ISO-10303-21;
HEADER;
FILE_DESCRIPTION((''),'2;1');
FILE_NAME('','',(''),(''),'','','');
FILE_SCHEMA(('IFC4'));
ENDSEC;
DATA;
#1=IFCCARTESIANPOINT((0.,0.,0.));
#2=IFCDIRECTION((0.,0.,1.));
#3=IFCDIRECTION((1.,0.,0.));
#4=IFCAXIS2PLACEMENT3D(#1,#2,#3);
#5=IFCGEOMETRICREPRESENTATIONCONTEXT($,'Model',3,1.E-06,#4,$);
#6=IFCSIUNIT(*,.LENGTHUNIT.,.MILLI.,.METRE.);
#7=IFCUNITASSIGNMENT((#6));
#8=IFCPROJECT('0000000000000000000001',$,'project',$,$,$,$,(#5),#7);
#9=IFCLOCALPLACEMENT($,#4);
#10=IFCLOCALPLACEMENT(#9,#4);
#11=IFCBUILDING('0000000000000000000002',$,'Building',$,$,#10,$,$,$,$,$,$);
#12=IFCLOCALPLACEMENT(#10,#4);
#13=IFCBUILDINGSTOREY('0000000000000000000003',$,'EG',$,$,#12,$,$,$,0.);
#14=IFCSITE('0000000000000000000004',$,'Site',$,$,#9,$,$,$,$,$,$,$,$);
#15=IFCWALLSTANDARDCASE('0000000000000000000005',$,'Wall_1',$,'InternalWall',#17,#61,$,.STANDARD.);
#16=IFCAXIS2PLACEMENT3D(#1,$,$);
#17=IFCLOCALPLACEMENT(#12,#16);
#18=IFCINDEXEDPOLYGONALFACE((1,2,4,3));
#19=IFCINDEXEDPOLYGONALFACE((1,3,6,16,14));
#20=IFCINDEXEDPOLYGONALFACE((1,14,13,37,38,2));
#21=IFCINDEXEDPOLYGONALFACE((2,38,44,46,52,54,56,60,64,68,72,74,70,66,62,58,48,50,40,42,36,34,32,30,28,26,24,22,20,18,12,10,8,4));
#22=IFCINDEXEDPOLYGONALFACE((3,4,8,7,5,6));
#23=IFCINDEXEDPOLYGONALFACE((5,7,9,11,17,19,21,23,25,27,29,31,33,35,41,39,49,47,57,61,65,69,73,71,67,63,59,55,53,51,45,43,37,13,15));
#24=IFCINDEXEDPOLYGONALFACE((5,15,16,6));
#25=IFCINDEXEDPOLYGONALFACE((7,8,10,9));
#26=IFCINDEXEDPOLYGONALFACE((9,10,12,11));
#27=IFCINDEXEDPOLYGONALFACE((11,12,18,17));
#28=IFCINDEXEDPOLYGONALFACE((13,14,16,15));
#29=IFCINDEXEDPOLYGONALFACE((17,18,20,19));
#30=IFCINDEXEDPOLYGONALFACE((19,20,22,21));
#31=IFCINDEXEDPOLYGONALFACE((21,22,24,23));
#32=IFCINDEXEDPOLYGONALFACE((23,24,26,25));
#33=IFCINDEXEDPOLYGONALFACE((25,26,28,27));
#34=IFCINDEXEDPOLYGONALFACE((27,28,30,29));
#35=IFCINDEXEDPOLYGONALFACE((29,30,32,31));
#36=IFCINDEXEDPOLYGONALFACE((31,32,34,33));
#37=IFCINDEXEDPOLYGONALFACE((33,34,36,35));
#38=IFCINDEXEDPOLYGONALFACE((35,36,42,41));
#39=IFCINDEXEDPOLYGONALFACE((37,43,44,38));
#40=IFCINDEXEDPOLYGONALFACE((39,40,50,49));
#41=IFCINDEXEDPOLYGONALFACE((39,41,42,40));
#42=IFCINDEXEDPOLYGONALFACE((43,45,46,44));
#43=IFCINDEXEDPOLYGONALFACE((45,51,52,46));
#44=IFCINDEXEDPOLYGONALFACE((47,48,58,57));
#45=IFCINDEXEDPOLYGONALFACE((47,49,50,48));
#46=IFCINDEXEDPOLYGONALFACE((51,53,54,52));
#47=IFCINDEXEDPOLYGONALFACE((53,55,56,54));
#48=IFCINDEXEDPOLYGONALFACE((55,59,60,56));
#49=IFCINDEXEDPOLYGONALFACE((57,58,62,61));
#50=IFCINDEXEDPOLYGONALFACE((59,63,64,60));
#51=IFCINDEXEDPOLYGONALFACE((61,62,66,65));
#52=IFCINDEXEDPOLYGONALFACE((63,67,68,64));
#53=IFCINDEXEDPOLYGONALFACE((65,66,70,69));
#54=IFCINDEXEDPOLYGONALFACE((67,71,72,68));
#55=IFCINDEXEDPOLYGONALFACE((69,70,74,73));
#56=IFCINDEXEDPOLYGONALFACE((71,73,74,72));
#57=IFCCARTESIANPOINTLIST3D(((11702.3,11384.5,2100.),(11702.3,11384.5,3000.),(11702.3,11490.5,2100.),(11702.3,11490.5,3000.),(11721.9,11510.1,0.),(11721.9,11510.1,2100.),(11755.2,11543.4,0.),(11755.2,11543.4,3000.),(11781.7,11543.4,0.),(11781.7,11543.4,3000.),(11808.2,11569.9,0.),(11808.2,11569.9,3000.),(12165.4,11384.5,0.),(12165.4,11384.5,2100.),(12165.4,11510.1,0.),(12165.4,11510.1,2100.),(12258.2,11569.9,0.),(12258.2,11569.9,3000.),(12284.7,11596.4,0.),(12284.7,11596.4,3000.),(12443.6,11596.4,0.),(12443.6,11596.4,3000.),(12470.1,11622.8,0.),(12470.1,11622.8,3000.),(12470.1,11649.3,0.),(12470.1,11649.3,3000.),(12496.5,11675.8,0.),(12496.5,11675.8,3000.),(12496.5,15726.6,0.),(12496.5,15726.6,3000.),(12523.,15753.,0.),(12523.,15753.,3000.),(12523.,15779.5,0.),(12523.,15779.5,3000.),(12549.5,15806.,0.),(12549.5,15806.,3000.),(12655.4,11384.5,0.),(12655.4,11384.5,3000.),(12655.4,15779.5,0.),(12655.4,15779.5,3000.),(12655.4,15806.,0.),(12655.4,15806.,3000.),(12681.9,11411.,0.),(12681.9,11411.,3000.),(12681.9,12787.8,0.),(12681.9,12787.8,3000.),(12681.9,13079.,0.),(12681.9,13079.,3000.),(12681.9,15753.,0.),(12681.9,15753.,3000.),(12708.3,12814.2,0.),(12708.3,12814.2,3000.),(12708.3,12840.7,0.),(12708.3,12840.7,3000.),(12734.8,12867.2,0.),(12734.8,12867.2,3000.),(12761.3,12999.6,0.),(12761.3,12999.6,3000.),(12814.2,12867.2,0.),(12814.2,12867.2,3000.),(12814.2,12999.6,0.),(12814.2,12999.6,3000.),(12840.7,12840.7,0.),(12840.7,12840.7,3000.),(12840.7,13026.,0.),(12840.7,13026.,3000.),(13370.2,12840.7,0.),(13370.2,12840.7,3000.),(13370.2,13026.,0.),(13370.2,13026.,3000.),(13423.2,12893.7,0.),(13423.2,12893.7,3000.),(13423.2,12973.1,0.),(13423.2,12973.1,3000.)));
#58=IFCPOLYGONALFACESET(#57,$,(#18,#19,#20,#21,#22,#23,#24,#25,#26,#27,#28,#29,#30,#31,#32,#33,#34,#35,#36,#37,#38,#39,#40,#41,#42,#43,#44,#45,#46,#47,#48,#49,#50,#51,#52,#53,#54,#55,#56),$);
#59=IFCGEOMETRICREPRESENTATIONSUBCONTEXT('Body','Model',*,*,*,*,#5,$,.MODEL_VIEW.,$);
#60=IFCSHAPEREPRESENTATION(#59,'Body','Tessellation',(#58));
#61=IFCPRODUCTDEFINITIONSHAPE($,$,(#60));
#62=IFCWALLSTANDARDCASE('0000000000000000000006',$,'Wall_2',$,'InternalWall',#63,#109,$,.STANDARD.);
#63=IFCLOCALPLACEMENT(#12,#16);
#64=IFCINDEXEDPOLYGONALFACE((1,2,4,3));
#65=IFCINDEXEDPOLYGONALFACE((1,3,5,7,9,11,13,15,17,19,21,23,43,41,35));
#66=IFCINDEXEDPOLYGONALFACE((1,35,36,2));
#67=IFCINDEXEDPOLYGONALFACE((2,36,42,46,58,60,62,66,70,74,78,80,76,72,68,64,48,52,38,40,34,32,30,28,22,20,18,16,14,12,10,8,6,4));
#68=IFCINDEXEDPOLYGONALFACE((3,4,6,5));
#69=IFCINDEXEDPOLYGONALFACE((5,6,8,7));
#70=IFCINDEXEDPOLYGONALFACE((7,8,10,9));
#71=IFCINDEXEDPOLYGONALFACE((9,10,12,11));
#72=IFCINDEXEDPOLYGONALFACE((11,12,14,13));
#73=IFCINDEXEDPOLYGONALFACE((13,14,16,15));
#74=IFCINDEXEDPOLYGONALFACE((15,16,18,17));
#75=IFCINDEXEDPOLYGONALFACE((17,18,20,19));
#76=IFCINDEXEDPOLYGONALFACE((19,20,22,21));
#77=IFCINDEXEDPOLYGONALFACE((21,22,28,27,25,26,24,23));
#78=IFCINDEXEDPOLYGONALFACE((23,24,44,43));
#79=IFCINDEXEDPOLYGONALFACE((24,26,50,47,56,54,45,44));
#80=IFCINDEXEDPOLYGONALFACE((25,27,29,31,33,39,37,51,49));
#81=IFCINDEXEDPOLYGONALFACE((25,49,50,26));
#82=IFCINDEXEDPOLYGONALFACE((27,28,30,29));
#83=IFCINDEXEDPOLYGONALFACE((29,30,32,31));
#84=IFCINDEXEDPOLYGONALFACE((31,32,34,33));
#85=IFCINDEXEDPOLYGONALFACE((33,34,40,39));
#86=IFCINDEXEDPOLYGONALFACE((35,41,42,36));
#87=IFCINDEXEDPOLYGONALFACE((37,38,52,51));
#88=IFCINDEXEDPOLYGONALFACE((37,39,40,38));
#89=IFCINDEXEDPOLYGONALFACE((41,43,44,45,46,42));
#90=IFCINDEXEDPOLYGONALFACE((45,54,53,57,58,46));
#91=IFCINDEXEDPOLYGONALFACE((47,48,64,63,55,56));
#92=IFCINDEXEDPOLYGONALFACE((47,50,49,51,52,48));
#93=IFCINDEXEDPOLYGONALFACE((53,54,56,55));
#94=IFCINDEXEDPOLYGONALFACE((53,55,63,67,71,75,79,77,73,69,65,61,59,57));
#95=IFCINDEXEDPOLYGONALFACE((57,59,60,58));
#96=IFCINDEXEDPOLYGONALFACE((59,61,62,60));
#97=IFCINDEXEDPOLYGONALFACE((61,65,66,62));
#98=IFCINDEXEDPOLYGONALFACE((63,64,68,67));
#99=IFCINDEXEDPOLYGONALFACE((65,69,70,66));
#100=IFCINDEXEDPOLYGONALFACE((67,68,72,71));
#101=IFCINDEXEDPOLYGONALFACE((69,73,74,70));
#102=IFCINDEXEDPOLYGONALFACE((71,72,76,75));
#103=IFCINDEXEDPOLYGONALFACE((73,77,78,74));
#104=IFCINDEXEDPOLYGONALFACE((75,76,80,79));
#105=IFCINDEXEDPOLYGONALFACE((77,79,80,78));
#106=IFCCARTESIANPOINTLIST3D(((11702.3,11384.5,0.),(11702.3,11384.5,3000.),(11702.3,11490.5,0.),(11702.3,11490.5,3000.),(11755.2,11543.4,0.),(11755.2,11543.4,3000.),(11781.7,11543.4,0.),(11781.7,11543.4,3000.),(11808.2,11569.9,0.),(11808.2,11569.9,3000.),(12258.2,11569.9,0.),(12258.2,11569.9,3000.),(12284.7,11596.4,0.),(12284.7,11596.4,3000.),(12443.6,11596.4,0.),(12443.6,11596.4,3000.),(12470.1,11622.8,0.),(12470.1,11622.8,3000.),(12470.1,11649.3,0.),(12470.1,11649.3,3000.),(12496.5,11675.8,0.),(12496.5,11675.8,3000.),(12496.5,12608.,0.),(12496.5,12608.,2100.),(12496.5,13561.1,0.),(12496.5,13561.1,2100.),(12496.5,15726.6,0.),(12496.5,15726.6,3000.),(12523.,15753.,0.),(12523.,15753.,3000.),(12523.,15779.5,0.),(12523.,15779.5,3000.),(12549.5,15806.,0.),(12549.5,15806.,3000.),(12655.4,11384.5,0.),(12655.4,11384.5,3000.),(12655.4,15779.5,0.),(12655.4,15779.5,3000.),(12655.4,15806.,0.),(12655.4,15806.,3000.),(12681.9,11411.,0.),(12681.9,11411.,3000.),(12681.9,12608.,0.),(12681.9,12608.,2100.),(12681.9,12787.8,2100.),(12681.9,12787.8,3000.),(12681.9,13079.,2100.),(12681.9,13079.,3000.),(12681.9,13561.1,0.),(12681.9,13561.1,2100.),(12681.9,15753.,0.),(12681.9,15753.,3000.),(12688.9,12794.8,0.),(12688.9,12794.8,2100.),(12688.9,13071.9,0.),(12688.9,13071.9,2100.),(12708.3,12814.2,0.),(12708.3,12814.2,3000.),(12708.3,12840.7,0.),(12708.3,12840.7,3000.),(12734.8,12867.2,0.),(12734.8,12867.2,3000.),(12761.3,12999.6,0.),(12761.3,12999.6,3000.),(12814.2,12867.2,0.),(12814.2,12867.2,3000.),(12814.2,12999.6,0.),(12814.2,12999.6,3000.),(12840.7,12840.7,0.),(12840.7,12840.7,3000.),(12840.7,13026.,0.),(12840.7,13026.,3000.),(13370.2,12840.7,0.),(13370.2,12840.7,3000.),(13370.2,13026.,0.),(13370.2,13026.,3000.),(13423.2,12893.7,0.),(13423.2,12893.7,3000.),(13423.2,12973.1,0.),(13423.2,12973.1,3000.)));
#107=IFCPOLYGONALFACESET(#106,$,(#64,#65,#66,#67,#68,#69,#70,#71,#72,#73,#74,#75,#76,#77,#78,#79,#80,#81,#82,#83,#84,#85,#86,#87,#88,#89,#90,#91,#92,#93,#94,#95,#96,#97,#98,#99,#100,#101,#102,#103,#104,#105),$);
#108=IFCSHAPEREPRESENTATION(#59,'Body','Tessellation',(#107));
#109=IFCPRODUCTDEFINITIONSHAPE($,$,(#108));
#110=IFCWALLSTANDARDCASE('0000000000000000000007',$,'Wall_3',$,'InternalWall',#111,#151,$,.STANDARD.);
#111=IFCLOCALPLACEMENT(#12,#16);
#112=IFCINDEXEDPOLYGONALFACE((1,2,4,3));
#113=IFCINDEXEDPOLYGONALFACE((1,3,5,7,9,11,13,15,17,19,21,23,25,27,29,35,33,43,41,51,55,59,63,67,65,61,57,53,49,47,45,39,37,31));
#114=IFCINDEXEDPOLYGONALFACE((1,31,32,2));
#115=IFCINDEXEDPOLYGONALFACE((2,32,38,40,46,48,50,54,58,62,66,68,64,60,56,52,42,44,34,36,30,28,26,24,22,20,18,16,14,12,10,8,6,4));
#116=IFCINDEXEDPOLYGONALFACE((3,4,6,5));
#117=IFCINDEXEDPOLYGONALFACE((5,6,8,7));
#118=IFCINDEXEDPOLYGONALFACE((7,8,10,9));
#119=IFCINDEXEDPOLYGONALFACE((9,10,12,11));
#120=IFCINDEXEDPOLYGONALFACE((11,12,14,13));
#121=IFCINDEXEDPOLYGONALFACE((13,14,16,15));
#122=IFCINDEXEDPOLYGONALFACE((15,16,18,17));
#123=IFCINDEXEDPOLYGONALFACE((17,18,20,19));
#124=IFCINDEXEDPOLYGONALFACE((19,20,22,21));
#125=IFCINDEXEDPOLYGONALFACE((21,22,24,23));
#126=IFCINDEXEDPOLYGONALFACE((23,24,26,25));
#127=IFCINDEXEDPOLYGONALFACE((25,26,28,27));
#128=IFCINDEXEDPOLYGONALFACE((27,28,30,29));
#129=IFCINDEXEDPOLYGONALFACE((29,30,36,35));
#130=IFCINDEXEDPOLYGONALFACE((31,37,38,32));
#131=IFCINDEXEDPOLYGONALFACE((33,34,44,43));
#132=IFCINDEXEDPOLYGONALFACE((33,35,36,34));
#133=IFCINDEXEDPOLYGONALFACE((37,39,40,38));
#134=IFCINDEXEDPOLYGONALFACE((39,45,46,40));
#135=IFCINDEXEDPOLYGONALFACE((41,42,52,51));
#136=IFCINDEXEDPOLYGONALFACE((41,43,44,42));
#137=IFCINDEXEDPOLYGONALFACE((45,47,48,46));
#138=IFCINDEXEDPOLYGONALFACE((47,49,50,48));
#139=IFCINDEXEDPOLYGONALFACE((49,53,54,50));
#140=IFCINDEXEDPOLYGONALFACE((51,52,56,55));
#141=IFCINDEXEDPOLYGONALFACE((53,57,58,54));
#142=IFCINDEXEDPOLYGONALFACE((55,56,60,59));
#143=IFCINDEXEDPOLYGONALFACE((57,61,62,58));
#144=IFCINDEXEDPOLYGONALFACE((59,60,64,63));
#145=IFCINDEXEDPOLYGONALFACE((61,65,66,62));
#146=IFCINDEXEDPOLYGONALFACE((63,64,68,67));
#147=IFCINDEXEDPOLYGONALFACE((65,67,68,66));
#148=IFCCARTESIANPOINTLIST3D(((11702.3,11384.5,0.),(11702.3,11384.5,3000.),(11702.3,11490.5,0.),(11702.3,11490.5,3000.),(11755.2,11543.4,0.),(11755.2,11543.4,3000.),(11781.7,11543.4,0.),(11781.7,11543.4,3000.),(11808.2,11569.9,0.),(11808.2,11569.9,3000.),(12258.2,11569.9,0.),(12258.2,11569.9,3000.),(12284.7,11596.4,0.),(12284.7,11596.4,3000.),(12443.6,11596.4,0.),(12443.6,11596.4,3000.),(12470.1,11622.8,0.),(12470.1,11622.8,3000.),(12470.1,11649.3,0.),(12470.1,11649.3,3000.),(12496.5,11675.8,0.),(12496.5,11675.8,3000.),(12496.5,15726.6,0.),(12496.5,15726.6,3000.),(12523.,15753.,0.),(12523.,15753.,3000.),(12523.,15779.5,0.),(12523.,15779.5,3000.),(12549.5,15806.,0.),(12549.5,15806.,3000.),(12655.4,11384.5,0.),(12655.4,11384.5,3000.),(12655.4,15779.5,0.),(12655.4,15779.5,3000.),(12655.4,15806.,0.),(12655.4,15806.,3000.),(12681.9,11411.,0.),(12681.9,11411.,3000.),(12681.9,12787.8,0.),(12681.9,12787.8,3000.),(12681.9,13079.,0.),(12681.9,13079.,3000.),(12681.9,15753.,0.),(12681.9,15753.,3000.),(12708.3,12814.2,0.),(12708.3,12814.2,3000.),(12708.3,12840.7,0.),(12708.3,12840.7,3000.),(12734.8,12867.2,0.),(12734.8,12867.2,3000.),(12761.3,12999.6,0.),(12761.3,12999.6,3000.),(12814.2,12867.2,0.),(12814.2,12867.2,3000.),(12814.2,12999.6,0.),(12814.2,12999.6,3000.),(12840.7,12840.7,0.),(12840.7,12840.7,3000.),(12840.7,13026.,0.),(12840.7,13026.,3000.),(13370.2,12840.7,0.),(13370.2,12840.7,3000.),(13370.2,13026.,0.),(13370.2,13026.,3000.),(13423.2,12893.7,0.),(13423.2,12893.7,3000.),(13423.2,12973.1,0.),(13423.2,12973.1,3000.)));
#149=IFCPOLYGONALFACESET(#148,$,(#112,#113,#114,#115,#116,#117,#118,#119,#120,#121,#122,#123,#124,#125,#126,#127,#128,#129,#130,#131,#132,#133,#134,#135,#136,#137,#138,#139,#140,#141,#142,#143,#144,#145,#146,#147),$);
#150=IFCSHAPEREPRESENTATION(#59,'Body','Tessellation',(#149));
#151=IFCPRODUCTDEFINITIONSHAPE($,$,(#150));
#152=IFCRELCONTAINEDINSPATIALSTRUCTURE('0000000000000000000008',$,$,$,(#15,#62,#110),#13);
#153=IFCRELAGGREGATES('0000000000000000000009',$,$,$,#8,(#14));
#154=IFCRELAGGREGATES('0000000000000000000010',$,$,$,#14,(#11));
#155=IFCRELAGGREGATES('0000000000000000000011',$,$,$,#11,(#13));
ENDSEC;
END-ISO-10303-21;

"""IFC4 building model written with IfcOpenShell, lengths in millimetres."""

from ifc_helpers import new_model, si_unit, frame, origin_with_axes, place, context, subcontext, project, spatial, polyline, rectangle, outline, extrude, element, save


model = new_model("IFC4")

# Units and contexts
model_context = context("Model", 3, precision=1e-06, world=origin_with_axes())
body_context = subcontext(model_context, "Body", "Model", "MODEL_VIEW")
ifc_project = project(units=[si_unit("LENGTHUNIT", "METRE", prefix="MILLI")], contexts=[model_context])

# Site, building, storey
site_placement = place(None, origin_with_axes())
site = spatial("IfcSite", under=ifc_project, at=site_placement, Name="Site")
building_placement = place(site_placement, origin_with_axes())
building = spatial("IfcBuilding", under=site, at=building_placement, Name="Building")
storey_placement = place(building_placement, origin_with_axes())
storey = spatial("IfcBuildingStorey", under=building, at=storey_placement, Name="EG", Elevation=0.0)

# Walls, openings
wall_1_placement = place(storey_placement, origin_with_axes())
wall_1 = element("IfcWallStandardCase", 1, at=wall_1_placement, inside=storey, Name="Wall_1", ObjectType="InternalWall", PredefinedType="STANDARD", context=body_context, shape_type="SweptSolid", body=[
    extrude(outline(polyline([(11702.3, 11384.5, 0.0), (11702.3, 11490.5, 0.0), (11755.2, 11543.4, 0.0), (11781.7, 11543.4, 0.0), (11808.2, 11569.9, 0.0), (12258.2, 11569.9, 0.0), (12284.7, 11596.4, 0.0), (12443.6, 11596.4, 0.0), (12470.1, 11622.8, 0.0), (12470.1, 11649.3, 0.0), (12496.5, 11675.8, 0.0), (12496.5, 15726.6, 0.0), (12523.0, 15753.0, 0.0), (12523.0, 15779.5, 0.0), (12549.5, 15806.0, 0.0), (12655.4, 15806.0, 0.0), (12655.4, 15779.5, 0.0), (12681.9, 15753.0, 0.0), (12681.9, 13079.0, 0.0), (12761.3, 12999.6, 0.0), (12814.2, 12999.6, 0.0), (12840.7, 13026.0, 0.0), (13370.2, 13026.0, 0.0), (13423.2, 12973.1, 0.0), (13423.2, 12893.7, 0.0), (13370.2, 12840.7, 0.0), (12840.7, 12840.7, 0.0), (12814.2, 12867.2, 0.0), (12734.8, 12867.2, 0.0), (12708.3, 12840.7, 0.0), (12708.3, 12814.2, 0.0), (12681.9, 12787.8, 0.0), (12681.9, 11411.0, 0.0), (12655.4, 11384.5, 0.0), (11702.3, 11384.5, 0.0)])), origin_with_axes(), (0.0, 0.0, 1.0), 3000.0),
])
opening_1_placement = place(wall_1_placement, origin_with_axes())
element("IfcOpeningElement", 2, at=opening_1_placement, inside=storey, cuts=wall_1, context=body_context, shape_type="SweptSolid", body=[
    extrude(rectangle(XDim=915.1, YDim=240.0), frame((11707.8, 11390.1, 0.0), z_axis=(0.0, 0.0, 1.0), x_axis=(1.0, 0.0, 0.0)), (0.0, 0.0, 1.0), 2100.0),
])
wall_2_placement = place(storey_placement, origin_with_axes())
wall_2 = element("IfcWallStandardCase", 3, at=wall_2_placement, inside=storey, Name="Wall_2", ObjectType="InternalWall", PredefinedType="STANDARD", context=body_context, shape_type="SweptSolid", body=[
    extrude(outline(polyline([(11702.3, 11384.5, 0.0), (11702.3, 11490.5, 0.0), (11755.2, 11543.4, 0.0), (11781.7, 11543.4, 0.0), (11808.2, 11569.9, 0.0), (12258.2, 11569.9, 0.0), (12284.7, 11596.4, 0.0), (12443.6, 11596.4, 0.0), (12470.1, 11622.8, 0.0), (12470.1, 11649.3, 0.0), (12496.5, 11675.8, 0.0), (12496.5, 15726.6, 0.0), (12523.0, 15753.0, 0.0), (12523.0, 15779.5, 0.0), (12549.5, 15806.0, 0.0), (12655.4, 15806.0, 0.0), (12655.4, 15779.5, 0.0), (12681.9, 15753.0, 0.0), (12681.9, 13079.0, 0.0), (12761.3, 12999.6, 0.0), (12814.2, 12999.6, 0.0), (12840.7, 13026.0, 0.0), (13370.2, 13026.0, 0.0), (13423.2, 12973.1, 0.0), (13423.2, 12893.7, 0.0), (13370.2, 12840.7, 0.0), (12840.7, 12840.7, 0.0), (12814.2, 12867.2, 0.0), (12734.8, 12867.2, 0.0), (12708.3, 12840.7, 0.0), (12708.3, 12814.2, 0.0), (12681.9, 12787.8, 0.0), (12681.9, 11411.0, 0.0), (12655.4, 11384.5, 0.0), (11702.3, 11384.5, 0.0)])), origin_with_axes(), (0.0, 0.0, 1.0), 3000.0),
])
opening_2_placement = place(wall_2_placement, origin_with_axes())
element("IfcOpeningElement", 4, at=opening_2_placement, inside=storey, cuts=wall_2, context=body_context, shape_type="SweptSolid", body=[
    extrude(rectangle(XDim=953.1, YDim=240.0), frame((12568.9, 13084.5, 0.0), z_axis=(0.0, 0.0, 1.0), x_axis=(0.0, 1.0, 0.0)), (0.0, 0.0, 1.0), 2100.0),
])

# Wall
for number, where, z_axis, x_axis, name in (
    (5, (0.0, 0.0, 0.0), (0.0, 0.0, 1.0), (1.0, 0.0, 0.0), "Wall_3"),
):
    element("IfcWallStandardCase", number, at=place(storey_placement, frame(where, z_axis=z_axis, x_axis=x_axis)), inside=storey, Name=name, ObjectType="InternalWall", PredefinedType="STANDARD", context=body_context, shape_type="SweptSolid", body=[
        extrude(outline(polyline([(11702.3, 11384.5, 0.0), (11702.3, 11490.5, 0.0), (11755.2, 11543.4, 0.0), (11781.7, 11543.4, 0.0), (11808.2, 11569.9, 0.0), (12258.2, 11569.9, 0.0), (12284.7, 11596.4, 0.0), (12443.6, 11596.4, 0.0), (12470.1, 11622.8, 0.0), (12470.1, 11649.3, 0.0), (12496.5, 11675.8, 0.0), (12496.5, 15726.6, 0.0), (12523.0, 15753.0, 0.0), (12523.0, 15779.5, 0.0), (12549.5, 15806.0, 0.0), (12655.4, 15806.0, 0.0), (12655.4, 15779.5, 0.0), (12681.9, 15753.0, 0.0), (12681.9, 13079.0, 0.0), (12761.3, 12999.6, 0.0), (12814.2, 12999.6, 0.0), (12840.7, 13026.0, 0.0), (13370.2, 13026.0, 0.0), (13423.2, 12973.1, 0.0), (13423.2, 12893.7, 0.0), (13370.2, 12840.7, 0.0), (12840.7, 12840.7, 0.0), (12814.2, 12867.2, 0.0), (12734.8, 12867.2, 0.0), (12708.3, 12840.7, 0.0), (12708.3, 12814.2, 0.0), (12681.9, 12787.8, 0.0), (12681.9, 11411.0, 0.0), (12655.4, 11384.5, 0.0), (11702.3, 11384.5, 0.0)])), origin_with_axes(), (0.0, 0.0, 1.0), 3000.0),
    ])

save(model, "model.ifc")
